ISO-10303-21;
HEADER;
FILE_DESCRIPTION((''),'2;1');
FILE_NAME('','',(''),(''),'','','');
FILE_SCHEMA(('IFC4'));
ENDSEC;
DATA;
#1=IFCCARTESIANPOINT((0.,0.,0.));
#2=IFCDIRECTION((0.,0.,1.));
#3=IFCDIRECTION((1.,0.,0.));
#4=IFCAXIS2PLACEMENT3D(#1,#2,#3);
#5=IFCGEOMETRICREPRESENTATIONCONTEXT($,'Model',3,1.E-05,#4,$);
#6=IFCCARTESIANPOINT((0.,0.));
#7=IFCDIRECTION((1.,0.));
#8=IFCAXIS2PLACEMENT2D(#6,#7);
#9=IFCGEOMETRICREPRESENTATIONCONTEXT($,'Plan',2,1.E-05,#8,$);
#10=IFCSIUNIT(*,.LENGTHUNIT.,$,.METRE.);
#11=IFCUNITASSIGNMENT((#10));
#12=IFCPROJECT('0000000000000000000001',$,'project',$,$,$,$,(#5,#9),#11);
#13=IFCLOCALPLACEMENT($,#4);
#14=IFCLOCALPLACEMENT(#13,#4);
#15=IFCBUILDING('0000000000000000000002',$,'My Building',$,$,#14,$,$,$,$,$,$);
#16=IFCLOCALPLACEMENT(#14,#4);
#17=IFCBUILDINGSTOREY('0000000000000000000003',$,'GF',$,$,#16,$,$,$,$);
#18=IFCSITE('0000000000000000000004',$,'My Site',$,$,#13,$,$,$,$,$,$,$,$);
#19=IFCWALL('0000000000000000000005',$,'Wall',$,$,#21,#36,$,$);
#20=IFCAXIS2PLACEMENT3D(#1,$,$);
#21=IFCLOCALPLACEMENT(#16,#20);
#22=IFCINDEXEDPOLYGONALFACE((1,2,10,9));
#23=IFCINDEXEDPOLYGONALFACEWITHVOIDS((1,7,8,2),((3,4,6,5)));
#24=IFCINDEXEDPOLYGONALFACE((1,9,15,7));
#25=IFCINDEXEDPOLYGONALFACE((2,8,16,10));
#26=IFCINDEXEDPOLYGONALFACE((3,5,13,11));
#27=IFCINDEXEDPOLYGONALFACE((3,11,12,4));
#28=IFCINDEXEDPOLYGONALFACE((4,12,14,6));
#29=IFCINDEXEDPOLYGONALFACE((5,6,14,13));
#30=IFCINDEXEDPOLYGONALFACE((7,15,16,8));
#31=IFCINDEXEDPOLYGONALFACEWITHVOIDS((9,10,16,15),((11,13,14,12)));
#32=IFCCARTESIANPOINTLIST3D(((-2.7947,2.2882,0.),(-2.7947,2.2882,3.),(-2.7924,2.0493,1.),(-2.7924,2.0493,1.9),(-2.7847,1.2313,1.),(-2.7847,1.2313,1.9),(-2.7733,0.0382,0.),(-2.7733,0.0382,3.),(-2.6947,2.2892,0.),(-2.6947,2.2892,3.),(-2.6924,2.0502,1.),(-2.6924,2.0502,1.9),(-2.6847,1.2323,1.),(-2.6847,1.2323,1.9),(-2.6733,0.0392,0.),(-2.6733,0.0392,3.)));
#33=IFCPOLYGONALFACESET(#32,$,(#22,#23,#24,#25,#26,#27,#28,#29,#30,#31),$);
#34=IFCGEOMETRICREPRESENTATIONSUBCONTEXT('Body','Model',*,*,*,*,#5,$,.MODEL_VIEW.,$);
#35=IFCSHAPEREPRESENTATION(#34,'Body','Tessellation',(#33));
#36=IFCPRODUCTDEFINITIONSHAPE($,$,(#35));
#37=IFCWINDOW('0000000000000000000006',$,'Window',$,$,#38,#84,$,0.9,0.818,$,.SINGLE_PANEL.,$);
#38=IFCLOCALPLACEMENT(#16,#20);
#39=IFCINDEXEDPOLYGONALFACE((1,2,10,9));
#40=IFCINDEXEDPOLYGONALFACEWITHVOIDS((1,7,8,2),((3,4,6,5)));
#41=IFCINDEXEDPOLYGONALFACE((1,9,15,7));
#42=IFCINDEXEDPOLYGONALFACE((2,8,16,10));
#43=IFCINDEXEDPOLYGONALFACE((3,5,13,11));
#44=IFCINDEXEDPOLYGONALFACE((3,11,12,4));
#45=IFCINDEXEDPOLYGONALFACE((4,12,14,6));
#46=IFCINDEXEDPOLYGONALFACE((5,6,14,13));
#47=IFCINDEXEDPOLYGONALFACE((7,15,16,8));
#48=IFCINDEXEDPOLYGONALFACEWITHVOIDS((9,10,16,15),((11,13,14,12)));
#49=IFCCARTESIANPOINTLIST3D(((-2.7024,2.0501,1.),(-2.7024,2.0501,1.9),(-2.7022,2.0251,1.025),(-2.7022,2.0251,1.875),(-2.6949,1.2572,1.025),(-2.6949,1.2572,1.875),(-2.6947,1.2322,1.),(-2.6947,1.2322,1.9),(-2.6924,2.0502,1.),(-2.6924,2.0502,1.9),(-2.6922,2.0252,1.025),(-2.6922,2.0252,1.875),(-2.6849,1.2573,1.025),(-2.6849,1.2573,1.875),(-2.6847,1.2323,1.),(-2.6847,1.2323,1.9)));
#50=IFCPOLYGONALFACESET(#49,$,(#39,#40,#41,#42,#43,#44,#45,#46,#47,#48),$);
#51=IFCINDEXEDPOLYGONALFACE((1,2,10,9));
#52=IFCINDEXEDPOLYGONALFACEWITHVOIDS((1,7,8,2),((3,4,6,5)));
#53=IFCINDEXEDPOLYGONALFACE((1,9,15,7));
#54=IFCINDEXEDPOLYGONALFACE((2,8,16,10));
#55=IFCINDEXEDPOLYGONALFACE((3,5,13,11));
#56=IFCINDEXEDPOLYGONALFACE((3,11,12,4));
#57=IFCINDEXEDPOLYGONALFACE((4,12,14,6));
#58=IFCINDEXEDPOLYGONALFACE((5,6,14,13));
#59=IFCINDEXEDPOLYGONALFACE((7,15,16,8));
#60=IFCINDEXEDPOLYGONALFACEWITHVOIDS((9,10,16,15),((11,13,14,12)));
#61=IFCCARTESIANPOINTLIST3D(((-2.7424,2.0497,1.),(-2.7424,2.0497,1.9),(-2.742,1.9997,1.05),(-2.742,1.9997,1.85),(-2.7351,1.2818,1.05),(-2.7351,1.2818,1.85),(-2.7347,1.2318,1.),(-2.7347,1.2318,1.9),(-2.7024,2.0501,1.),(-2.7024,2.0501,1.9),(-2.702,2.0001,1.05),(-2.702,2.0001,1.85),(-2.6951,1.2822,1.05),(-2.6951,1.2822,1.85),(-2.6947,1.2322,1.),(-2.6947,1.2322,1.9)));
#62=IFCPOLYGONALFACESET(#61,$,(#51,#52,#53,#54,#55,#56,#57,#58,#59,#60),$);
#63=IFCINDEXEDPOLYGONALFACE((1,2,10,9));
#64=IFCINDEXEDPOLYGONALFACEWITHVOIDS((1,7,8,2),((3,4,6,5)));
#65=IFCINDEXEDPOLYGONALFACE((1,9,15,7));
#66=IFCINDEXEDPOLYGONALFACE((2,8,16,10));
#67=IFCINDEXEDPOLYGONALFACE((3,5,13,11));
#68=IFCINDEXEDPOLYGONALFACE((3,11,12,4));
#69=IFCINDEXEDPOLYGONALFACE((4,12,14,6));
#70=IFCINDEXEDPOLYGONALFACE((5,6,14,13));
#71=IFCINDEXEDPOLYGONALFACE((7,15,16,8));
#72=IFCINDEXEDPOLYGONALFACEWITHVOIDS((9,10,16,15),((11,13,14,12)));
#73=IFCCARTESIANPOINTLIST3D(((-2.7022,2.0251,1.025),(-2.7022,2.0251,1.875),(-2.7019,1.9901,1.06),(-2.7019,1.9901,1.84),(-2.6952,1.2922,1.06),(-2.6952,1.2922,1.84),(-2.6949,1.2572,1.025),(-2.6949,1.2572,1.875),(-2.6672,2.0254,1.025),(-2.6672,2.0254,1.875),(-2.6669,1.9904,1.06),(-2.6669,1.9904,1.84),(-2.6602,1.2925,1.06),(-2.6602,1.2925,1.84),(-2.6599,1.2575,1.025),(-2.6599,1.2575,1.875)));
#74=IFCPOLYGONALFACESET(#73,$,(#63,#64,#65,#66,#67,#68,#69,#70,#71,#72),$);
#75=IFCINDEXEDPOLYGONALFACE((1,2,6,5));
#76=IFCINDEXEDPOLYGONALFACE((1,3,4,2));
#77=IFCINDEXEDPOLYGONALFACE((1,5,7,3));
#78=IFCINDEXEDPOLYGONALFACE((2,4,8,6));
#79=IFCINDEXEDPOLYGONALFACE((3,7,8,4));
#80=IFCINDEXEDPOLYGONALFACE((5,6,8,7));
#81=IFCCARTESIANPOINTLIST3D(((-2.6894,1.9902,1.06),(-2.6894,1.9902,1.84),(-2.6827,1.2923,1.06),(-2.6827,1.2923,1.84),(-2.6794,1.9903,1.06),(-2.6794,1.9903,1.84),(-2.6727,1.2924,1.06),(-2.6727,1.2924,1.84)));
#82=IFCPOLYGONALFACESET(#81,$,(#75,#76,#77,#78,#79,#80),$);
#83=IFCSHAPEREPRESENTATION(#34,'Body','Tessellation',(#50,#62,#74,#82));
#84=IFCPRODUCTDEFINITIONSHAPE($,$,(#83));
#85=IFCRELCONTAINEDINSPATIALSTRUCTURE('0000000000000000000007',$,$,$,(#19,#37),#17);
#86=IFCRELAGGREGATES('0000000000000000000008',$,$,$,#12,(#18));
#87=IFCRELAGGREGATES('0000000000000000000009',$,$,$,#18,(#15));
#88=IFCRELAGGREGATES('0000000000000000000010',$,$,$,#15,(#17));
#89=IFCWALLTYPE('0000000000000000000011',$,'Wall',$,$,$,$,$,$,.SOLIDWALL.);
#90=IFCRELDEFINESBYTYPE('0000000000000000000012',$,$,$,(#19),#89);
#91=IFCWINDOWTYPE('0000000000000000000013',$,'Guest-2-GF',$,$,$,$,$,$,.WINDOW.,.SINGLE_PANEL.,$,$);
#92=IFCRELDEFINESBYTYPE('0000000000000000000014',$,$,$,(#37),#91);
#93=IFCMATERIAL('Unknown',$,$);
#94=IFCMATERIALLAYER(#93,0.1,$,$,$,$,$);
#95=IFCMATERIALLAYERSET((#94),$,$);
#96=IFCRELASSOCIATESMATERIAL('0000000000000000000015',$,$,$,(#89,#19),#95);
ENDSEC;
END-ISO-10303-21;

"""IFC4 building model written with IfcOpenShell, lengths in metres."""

from ifc_helpers import new_model, entity, si_unit, frame, origin_with_axes, origin_2d_with_axis, place, context, subcontext, project, spatial, line, indexed_curve, outline, extrude, shape, source, transform, mapped, material, layer, layer_set, layer_usage, type_object, type_shapes, element, fill, save


model = new_model("IFC4")

# Units and contexts
model_context = context("Model", 3, precision=1e-05, world=origin_with_axes())
plan_context = context("Plan", 2, precision=1e-05, world=origin_2d_with_axis())
body_context_1 = subcontext(model_context, "Body", "Model", "MODEL_VIEW")
body_context_2 = subcontext(plan_context, "Body", "Plan", "PLAN_VIEW")
ifc_project = project(units=[si_unit("LENGTHUNIT", "METRE")], contexts=[model_context, plan_context])

# Site, building, storey
site_placement = place(None, origin_with_axes())
site = spatial("IfcSite", under=ifc_project, at=site_placement, Name="My Site")
building_placement = place(site_placement, origin_with_axes())
building = spatial("IfcBuilding", under=site, at=building_placement, Name="My Building")
storey_placement = place(building_placement, origin_with_axes())
storey = spatial("IfcBuildingStorey", under=building, at=storey_placement, Name="GF")

# Shared definitions
ifc_material_1 = material(Name="Unknown")

# Shared definitions
ifc_layer_1 = layer(ifc_material_1, 0.1)
ifc_layer_set_1 = layer_set([ifc_layer_1])
wall_type = type_object("IfcWallType", Name="Wall", PredefinedType="SOLIDWALL", material=ifc_layer_set_1)

# Wall, opening, window
ifc_layer_usage_1 = layer_usage(ifc_layer_set_1, "AXIS2", "POSITIVE", 0.0)
wall_1_placement = place(storey_placement, frame((-2.7947, 2.2882, 0.0), z_axis=(0.0, 0.0, 1.0), x_axis=(0.009494, -0.999955, 0.0)))
wall_1 = element("IfcWall", 1, at=wall_1_placement, inside=storey, type_object=wall_type, material=ifc_layer_usage_1, Name="Wall", context=body_context_1, shape_type="SweptSolid", body=[
    extrude(outline(indexed_curve([(0.0, 0.0), (0.0, 0.1), (2.2501, 0.1), (2.2501, 0.0)], segments=[line(1, 2, 3, 4, 1)])), origin_with_axes(), (0.0, 0.0, 1.0), 3.0),
])
shared_shape_1 = source(origin_with_axes(), body_context_1, "Body", "SweptSolid", [
    extrude(outline(indexed_curve([(0.0, 0.0), (0.818, 0.0), (0.818, 0.9), (0.0, 0.9)], segments=[line(1, 2, 3, 4, 1)])), frame((0.0, -0.6, 0.0), z_axis=(0.0, -1.0, 0.0), x_axis=(1.0, 0.0, 0.0)), (0.0, 0.0, -1.0), 1.2),
])
opening_1_placement = place(wall_1_placement, frame((0.239, 0.0, 1.0), z_axis=(0.0, 0.0, 1.0), x_axis=(1.0, 0.0, 0.0)))
opening_1 = element("IfcOpeningElement", 2, at=opening_1_placement, cuts=wall_1, PredefinedType="OPENING", context=body_context_1, shape_type="MappedRepresentation", body=[
    mapped(shared_shape_1, transform((0.0, 0.0, 0.0), x_axis=(1.0, 0.0, 0.0), y_axis=(0.0, 1.0, 0.0), z_axis=(0.0, 0.0, 1.0), scale=1.0)),
])
window_type_1 = type_object("IfcWindowType", Name="Guest-2-GF", PartitioningType="SINGLE_PANEL", PredefinedType="WINDOW")
shared_shape_2 = source(origin_with_axes(), body_context_1, "Body", "SweptSolid", [
    extrude(outline(indexed_curve([(0.0, 0.0), (0.818, 0.0), (0.818, 0.9), (0.0, 0.9)], segments=[line(1, 2, 3, 4, 1)]), holes=[indexed_curve([(0.025, 0.025), (0.793, 0.025), (0.793, 0.875), (0.025, 0.875)], segments=[line(1, 2, 3, 4, 1)])]), frame((0.0, 0.09, 0.0), z_axis=(0.0, -1.0, 0.0), x_axis=(1.0, 0.0, 0.0)), (0.0, 0.0, -1.0), 0.01),
    extrude(outline(indexed_curve([(0.0, 0.0), (0.818, 0.0), (0.818, 0.9), (0.0, 0.9)], segments=[line(1, 2, 3, 4, 1)]), holes=[indexed_curve([(0.05, 0.05), (0.768, 0.05), (0.768, 0.85), (0.05, 0.85)], segments=[line(1, 2, 3, 4, 1)])]), frame((0.0, 0.05, 0.0), z_axis=(0.0, -1.0, 0.0), x_axis=(1.0, 0.0, 0.0)), (0.0, 0.0, -1.0), 0.04),
    extrude(outline(indexed_curve([(0.0, 0.0), (0.768, 0.0), (0.768, 0.85), (0.0, 0.85)], segments=[line(1, 2, 3, 4, 1)]), holes=[indexed_curve([(0.035, 0.035), (0.733, 0.035), (0.733, 0.815), (0.035, 0.815)], segments=[line(1, 2, 3, 4, 1)])]), frame((0.025, 0.09, 0.025), z_axis=(0.0, -1.0, 0.0), x_axis=(1.0, 0.0, 0.0)), (0.0, 0.0, -1.0), 0.035),
    extrude(outline(indexed_curve([(0.035, 0.035), (0.733, 0.035), (0.733, 0.815), (0.035, 0.815)], segments=[line(1, 2, 3, 4, 1)])), frame((0.025, 0.1025, 0.025), z_axis=(0.0, -1.0, 0.0), x_axis=(1.0, 0.0, 0.0)), (0.0, 0.0, -1.0), 0.01),
])
shared_shape_3 = source(origin_with_axes(), body_context_2, "Body", "Curve2D", [
    entity("IfcIndexedPolyCurve", entity("IfcCartesianPointList2D", [[0.05, 0.05], [0.768, 0.05]])),
    entity("IfcIndexedPolyCurve", entity("IfcCartesianPointList2D", [[0.0, 0.1], [0.025, 0.1], [0.025, 0.09], [0.05, 0.09], [0.05, 0.05], [0.0, 0.05]]), [entity("IfcLineIndex", [1, 2, 3, 4, 5, 6, 1])]),
    entity("IfcIndexedPolyCurve", entity("IfcCartesianPointList2D", [[0.818, 0.1], [0.793, 0.1], [0.793, 0.09], [0.768, 0.09], [0.768, 0.05], [0.818, 0.05]]), [entity("IfcLineIndex", [1, 2, 3, 4, 5, 6, 1])]),
    entity("IfcIndexedPolyCurve", entity("IfcCartesianPointList2D", [[0.025, 0.09], [0.06, 0.09], [0.06, 0.125], [0.025, 0.125]]), [entity("IfcLineIndex", [1, 2, 3, 4, 1])]),
    entity("IfcIndexedPolyCurve", entity("IfcCartesianPointList2D", [[0.793, 0.09], [0.758, 0.09], [0.758, 0.125], [0.793, 0.125]]), [entity("IfcLineIndex", [1, 2, 3, 4, 1])]),
    entity("IfcIndexedPolyCurve", entity("IfcCartesianPointList2D", [[0.06, 0.09], [0.758, 0.09]])),
    entity("IfcIndexedPolyCurve", entity("IfcCartesianPointList2D", [[0.06, 0.125], [0.758, 0.125]])),
    entity("IfcIndexedPolyCurve", entity("IfcCartesianPointList2D", [[0.06, 0.1075], [0.758, 0.1075]])),
])
type_shapes(window_type_1, [shared_shape_2, shared_shape_3])
window_1_placement = place(opening_1_placement, frame((0.0, 0.0, 0.0), z_axis=(0.0, 0.0, 1.0), x_axis=(1.0, 0.0, 0.0)))
window_1 = element("IfcWindow", 3, at=window_1_placement, inside=storey, type_object=window_type_1, Name="Window", OverallHeight=0.9, OverallWidth=0.818, PartitioningType="SINGLE_PANEL", shapes=[
    shape(body_context_1, "Body", "MappedRepresentation", [mapped(shared_shape_2, transform((0.0, 0.0, 0.0), x_axis=(1.0, 0.0, 0.0), y_axis=(0.0, 1.0, 0.0), z_axis=(0.0, 0.0, 1.0), scale=1.0))]),
    shape(body_context_2, "Body", "MappedRepresentation", [mapped(shared_shape_3, transform((0.0, 0.0, 0.0), x_axis=(1.0, 0.0, 0.0), y_axis=(0.0, 1.0, 0.0), z_axis=(0.0, 0.0, 1.0), scale=1.0))]),
])
fill(opening_1, window_1)

save(model, "model.ifc")
